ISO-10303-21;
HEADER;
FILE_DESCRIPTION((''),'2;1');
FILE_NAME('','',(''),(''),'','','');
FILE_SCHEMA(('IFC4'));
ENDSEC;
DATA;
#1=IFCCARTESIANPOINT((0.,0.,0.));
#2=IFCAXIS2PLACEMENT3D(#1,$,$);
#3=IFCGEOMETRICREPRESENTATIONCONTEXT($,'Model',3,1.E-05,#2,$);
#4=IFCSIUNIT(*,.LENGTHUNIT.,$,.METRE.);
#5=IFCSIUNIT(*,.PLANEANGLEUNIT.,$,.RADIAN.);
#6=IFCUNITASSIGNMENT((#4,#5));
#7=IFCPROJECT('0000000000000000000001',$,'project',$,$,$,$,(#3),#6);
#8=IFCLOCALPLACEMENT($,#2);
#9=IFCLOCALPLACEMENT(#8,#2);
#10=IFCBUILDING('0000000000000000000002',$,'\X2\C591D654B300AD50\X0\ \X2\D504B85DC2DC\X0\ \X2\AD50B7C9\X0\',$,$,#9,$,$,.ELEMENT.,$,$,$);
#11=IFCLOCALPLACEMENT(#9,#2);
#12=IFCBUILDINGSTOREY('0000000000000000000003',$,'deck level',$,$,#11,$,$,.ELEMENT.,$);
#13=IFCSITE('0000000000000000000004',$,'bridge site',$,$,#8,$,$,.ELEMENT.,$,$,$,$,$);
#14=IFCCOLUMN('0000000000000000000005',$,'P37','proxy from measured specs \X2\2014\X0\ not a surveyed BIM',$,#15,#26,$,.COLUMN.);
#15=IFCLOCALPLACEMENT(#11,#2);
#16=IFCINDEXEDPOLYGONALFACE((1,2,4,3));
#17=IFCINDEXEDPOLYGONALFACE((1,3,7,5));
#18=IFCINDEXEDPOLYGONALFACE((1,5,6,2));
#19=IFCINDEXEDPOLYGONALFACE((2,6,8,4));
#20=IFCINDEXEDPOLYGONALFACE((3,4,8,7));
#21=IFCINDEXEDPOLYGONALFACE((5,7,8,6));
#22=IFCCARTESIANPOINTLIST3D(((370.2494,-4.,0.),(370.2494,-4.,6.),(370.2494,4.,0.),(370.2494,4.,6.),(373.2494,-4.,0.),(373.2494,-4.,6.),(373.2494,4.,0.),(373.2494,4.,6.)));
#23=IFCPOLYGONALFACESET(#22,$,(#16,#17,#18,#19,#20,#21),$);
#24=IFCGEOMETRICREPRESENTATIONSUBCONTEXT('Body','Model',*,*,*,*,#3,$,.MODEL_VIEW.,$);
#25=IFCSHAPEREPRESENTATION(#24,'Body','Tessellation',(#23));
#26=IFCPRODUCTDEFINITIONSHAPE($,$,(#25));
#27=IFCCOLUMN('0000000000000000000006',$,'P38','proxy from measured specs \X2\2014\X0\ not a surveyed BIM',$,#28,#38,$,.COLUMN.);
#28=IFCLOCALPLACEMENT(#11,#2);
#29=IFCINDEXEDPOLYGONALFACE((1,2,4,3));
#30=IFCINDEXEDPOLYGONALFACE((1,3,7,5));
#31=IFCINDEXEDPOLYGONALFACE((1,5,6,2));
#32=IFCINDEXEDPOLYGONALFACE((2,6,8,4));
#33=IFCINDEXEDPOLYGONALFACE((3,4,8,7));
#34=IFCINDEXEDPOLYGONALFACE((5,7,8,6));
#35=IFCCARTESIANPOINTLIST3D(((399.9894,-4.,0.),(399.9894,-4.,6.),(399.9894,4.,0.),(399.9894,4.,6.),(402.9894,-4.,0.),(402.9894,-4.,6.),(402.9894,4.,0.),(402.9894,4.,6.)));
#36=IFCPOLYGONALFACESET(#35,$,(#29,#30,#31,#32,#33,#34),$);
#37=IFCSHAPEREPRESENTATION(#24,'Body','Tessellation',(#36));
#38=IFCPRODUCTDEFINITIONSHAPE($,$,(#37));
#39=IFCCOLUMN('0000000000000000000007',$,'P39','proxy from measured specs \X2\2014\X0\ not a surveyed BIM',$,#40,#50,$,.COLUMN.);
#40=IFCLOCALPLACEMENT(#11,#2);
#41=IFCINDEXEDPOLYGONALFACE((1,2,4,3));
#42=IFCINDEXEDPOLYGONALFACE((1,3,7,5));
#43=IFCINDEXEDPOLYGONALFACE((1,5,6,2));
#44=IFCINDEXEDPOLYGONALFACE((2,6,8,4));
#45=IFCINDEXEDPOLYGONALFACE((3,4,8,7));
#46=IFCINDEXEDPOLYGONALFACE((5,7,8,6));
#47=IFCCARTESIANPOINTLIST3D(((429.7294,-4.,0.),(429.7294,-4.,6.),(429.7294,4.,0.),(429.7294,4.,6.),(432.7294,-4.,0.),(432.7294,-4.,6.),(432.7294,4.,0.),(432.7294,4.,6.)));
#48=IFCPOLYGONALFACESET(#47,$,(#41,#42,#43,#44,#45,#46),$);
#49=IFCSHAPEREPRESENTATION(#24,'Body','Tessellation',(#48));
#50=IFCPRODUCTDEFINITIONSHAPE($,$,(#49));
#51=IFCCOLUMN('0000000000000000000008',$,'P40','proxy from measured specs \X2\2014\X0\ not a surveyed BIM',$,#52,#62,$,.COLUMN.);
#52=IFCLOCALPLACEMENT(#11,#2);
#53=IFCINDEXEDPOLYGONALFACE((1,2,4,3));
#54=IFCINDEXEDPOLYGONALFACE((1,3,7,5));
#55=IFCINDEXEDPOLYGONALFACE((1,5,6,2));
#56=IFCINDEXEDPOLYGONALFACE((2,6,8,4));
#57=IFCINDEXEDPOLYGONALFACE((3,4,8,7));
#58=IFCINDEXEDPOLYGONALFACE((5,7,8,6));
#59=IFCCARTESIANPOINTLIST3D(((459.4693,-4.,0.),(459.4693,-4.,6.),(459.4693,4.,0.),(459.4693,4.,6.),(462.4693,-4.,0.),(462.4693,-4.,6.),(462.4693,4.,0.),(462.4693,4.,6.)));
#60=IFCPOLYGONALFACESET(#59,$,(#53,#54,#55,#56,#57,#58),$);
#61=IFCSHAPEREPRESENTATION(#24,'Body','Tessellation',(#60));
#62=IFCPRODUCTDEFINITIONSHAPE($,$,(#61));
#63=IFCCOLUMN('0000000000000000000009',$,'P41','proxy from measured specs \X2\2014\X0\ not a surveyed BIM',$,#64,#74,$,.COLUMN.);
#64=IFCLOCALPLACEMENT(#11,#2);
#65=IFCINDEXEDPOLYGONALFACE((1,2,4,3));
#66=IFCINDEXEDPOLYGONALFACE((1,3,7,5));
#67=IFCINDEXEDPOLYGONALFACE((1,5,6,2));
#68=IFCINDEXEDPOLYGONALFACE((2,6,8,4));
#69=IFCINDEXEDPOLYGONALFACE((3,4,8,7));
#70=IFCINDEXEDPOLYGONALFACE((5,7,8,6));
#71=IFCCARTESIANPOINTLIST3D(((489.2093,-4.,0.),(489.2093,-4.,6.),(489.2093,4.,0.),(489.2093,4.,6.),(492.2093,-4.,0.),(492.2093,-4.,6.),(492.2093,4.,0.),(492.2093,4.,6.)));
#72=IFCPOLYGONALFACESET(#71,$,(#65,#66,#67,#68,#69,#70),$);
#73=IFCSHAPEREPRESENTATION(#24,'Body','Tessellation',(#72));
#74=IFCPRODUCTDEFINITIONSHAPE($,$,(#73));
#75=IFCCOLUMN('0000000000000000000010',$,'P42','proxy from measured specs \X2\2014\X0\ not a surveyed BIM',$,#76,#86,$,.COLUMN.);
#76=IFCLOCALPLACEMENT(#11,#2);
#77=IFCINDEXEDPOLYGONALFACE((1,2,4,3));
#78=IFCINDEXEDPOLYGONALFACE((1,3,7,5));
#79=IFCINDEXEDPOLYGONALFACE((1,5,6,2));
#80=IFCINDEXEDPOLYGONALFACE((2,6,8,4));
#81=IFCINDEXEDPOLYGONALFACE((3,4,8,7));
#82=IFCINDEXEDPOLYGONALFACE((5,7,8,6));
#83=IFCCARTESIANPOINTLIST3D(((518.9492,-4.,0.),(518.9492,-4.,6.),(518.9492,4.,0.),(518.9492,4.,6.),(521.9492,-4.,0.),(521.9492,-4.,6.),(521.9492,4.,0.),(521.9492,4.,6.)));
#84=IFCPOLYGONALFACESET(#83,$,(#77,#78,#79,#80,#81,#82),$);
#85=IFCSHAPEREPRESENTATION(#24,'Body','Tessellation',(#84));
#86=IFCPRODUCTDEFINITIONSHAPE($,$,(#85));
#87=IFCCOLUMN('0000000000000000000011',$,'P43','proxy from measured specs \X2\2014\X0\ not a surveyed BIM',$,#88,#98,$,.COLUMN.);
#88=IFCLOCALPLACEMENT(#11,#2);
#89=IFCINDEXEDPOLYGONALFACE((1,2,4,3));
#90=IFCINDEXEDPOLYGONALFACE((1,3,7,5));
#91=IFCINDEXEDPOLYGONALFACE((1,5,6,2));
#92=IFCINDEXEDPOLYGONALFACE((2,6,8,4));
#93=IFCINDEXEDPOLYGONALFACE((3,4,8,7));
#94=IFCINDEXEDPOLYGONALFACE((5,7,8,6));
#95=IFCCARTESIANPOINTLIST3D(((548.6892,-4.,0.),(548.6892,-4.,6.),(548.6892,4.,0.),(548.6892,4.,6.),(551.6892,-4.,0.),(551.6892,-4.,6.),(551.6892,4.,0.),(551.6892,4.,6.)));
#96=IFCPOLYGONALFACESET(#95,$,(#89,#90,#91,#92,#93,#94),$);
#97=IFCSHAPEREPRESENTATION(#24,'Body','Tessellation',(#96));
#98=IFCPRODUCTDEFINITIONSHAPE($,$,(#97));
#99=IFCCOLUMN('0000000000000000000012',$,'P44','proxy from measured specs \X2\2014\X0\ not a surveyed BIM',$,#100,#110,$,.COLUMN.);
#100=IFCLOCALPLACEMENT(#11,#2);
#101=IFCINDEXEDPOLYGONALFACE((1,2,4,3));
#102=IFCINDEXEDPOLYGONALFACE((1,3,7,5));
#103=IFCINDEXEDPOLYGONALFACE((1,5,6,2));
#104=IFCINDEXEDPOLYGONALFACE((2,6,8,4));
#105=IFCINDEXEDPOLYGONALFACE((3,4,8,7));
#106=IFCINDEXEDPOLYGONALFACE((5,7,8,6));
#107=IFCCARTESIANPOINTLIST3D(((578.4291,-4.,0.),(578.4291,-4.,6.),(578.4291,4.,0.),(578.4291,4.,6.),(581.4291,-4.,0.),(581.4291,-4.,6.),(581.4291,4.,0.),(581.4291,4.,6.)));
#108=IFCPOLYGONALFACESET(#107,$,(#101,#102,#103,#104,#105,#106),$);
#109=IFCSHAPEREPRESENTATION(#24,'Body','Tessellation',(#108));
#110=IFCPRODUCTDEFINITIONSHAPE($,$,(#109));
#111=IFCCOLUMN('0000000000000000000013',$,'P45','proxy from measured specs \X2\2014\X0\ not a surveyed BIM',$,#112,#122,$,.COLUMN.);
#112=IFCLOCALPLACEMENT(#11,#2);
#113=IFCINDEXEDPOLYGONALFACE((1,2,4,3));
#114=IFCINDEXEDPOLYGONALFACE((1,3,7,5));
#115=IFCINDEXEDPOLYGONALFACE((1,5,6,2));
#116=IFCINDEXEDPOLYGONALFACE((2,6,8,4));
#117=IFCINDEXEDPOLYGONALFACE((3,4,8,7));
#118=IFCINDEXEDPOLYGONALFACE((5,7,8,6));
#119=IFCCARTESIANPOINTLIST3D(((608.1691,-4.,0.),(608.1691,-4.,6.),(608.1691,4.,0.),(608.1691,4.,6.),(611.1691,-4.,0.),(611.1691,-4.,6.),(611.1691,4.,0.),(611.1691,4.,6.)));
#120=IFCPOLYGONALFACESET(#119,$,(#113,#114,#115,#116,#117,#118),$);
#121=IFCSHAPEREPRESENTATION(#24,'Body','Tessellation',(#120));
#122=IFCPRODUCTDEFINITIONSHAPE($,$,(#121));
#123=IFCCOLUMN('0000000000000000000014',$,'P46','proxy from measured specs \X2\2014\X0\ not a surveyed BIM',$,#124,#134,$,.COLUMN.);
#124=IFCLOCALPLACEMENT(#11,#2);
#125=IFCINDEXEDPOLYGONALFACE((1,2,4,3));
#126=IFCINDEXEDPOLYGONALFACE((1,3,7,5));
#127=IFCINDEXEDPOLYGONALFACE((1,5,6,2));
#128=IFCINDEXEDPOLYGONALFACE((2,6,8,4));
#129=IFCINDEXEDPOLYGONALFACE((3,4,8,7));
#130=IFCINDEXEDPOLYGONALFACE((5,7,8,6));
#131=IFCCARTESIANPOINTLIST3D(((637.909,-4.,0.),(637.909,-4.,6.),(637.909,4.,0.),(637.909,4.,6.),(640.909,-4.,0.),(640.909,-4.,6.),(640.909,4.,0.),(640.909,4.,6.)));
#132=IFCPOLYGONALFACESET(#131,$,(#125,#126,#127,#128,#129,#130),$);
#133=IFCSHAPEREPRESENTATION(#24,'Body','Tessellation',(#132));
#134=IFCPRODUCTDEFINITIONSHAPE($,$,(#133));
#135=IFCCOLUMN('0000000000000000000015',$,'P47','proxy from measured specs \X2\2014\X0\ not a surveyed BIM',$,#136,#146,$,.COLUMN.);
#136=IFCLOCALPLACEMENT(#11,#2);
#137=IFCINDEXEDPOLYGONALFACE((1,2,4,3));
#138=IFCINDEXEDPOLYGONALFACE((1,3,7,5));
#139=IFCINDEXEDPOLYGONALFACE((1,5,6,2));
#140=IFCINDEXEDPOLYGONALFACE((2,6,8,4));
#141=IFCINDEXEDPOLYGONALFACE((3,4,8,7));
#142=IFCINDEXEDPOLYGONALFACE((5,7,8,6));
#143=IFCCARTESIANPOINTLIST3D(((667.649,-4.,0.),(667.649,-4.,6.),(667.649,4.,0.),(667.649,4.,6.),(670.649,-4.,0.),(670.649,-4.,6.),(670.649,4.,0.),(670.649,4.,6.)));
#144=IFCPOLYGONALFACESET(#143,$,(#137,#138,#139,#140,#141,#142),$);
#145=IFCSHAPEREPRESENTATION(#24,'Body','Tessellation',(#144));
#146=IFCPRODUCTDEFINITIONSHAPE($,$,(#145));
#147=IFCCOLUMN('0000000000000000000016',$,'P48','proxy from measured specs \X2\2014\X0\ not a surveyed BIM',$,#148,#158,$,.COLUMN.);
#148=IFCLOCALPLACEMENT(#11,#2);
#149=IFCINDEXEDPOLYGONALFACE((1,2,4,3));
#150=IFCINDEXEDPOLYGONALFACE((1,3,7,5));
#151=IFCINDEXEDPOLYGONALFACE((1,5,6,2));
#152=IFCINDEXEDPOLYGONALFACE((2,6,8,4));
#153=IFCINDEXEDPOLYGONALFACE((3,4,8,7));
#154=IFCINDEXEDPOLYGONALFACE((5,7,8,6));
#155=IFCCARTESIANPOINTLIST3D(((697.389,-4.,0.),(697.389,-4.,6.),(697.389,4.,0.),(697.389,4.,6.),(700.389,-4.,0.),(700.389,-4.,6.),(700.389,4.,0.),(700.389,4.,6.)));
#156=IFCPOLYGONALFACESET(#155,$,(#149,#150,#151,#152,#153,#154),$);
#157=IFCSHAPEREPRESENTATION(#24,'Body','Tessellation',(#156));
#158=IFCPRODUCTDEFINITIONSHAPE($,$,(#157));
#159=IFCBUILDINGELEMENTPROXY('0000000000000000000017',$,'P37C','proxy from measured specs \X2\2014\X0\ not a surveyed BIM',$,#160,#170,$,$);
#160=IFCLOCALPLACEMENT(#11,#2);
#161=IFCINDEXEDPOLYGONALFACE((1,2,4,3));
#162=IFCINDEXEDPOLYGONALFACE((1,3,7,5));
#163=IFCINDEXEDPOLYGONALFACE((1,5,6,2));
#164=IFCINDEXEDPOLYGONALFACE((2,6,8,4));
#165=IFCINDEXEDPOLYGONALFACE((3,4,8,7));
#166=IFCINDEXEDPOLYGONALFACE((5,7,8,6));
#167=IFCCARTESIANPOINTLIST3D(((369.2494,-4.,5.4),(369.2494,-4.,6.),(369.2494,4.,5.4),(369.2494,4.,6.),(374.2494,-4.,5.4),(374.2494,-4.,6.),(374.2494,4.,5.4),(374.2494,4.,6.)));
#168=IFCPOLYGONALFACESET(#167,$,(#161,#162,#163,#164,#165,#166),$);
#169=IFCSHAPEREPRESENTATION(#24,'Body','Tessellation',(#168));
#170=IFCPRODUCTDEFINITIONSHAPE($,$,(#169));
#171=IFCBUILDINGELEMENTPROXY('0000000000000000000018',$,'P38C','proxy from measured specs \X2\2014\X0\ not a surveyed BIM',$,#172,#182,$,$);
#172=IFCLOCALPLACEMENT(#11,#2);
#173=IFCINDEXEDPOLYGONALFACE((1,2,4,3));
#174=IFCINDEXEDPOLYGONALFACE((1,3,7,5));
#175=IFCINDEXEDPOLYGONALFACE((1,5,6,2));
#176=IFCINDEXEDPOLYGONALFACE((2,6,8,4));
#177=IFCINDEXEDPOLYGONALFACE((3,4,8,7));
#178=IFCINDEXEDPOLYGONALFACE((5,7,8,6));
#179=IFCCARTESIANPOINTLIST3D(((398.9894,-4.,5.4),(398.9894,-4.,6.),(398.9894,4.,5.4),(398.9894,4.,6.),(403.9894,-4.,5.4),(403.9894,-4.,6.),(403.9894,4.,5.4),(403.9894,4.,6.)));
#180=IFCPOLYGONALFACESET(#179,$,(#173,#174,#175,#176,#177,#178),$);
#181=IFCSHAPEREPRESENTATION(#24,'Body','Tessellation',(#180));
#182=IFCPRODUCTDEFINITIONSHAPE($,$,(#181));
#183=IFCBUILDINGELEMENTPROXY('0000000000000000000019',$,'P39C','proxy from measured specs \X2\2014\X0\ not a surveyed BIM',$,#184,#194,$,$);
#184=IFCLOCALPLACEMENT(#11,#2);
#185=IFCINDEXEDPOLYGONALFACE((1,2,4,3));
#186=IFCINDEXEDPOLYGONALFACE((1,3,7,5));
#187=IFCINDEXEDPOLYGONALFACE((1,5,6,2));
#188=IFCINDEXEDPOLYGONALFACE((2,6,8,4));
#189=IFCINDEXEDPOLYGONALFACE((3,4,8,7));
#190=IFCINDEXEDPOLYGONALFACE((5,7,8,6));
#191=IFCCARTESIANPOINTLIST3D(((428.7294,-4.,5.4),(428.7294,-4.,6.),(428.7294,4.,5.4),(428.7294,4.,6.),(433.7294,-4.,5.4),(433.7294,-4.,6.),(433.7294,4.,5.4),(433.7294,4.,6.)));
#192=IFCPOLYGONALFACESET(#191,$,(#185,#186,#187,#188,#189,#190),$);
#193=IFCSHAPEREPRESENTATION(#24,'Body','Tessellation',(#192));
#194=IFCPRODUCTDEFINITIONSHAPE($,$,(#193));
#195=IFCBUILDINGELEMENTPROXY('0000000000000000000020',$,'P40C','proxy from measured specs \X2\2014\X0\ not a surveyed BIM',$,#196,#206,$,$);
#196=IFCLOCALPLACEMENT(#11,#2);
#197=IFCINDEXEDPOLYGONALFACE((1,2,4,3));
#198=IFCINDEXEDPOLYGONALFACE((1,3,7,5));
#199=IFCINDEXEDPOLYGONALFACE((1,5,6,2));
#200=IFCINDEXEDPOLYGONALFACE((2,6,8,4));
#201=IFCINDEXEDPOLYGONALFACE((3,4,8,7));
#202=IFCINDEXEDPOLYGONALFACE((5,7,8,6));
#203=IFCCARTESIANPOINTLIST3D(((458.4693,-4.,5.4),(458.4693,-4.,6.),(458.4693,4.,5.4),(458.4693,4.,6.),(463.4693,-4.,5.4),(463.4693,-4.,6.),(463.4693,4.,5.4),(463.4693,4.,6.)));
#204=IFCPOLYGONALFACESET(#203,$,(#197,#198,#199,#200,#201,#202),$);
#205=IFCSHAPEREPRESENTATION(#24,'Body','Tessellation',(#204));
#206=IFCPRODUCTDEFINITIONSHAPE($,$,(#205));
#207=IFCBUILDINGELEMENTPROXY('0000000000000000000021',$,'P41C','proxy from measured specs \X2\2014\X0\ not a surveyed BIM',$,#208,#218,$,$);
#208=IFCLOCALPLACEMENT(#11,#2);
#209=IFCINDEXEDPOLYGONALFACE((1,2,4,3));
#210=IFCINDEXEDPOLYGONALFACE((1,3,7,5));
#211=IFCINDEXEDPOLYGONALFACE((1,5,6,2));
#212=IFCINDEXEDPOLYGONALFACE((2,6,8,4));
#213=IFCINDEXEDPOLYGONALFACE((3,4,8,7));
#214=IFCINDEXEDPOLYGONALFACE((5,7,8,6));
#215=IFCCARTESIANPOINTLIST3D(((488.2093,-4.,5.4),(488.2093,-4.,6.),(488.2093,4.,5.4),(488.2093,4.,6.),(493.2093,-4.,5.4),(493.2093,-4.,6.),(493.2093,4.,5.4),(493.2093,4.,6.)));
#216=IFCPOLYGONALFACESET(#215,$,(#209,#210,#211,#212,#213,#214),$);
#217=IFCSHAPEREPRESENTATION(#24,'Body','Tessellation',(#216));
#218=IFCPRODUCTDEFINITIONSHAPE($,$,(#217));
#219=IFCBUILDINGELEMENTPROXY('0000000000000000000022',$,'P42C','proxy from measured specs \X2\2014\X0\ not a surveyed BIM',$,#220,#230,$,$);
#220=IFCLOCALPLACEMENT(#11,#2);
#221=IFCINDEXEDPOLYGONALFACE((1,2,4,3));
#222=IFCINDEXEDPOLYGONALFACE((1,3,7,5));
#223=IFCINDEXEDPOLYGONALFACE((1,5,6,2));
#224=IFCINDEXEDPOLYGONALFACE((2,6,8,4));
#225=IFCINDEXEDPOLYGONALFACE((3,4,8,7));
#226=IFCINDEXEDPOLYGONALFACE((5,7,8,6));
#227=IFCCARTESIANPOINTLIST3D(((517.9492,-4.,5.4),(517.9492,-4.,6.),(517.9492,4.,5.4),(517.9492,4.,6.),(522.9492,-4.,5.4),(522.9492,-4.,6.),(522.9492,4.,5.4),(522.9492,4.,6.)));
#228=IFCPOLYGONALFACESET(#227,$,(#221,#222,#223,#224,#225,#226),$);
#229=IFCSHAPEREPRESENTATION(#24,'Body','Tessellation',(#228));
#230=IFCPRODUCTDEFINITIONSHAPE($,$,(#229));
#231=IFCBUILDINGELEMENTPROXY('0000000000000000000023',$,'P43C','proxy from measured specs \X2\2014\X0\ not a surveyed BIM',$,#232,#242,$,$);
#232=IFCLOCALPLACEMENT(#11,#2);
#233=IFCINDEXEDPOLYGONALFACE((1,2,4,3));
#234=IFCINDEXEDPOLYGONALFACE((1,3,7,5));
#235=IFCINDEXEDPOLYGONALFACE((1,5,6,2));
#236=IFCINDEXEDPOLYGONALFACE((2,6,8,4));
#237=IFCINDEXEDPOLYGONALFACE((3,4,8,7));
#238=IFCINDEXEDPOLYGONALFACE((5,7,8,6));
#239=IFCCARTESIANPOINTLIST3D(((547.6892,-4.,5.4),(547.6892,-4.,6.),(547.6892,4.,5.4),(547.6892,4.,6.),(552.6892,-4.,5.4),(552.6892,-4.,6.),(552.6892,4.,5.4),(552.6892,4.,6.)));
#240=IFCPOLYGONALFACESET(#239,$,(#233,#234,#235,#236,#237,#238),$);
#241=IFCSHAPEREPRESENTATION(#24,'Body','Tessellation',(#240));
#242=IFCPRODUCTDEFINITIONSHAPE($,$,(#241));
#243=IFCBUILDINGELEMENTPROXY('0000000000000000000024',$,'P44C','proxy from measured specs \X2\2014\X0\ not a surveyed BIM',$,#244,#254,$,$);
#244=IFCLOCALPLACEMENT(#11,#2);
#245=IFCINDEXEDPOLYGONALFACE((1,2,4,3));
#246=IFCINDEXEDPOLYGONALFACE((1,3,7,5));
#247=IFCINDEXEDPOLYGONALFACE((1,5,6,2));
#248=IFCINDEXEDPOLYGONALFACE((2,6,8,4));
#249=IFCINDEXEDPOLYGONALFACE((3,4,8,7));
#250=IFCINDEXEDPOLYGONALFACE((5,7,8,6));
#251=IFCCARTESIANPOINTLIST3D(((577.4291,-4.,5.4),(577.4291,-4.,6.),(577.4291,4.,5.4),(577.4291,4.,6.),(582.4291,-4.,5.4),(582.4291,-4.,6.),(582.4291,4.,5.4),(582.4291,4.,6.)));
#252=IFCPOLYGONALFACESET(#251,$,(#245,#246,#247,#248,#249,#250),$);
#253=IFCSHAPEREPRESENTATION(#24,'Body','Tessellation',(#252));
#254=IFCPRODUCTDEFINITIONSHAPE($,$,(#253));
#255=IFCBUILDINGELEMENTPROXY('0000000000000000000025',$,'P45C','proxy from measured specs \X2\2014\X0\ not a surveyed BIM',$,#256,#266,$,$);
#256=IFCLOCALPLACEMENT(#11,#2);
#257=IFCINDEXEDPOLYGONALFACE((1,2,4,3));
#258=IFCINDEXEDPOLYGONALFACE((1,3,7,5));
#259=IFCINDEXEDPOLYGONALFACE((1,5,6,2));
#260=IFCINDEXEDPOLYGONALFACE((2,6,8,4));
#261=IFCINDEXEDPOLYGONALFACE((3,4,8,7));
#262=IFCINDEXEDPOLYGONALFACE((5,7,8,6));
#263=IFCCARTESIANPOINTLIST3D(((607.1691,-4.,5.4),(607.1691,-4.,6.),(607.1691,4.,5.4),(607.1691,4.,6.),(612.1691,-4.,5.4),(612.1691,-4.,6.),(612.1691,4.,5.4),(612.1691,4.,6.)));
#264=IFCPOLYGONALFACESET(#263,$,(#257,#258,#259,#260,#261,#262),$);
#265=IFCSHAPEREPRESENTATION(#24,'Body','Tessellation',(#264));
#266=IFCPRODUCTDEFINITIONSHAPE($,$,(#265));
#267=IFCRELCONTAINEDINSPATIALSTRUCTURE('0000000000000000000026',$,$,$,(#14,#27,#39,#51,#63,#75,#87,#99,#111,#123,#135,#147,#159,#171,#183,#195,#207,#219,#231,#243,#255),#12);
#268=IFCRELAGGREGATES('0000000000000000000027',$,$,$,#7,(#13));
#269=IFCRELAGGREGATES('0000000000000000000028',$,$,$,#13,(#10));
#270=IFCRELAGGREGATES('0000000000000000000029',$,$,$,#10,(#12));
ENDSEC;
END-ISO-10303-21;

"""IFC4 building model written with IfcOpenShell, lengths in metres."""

from ifc_helpers import new_model, si_unit, frame, origin, origin_2d, place, context, subcontext, project, spatial, rectangle, extrude, element, save


model = new_model("IFC4")

# Units and contexts
model_context = context("Model", 3, precision=1e-05, world=origin())
body_context = subcontext(model_context, "Body", "Model", "MODEL_VIEW")
ifc_project = project(units=[si_unit("LENGTHUNIT", "METRE"), si_unit("PLANEANGLEUNIT", "RADIAN")], contexts=[model_context])

# Site, building, storey
site_placement = place(None, origin())
site = spatial("IfcSite", under=ifc_project, at=site_placement, Name="bridge site", CompositionType="ELEMENT")
building_placement = place(site_placement, origin())
building = spatial("IfcBuilding", under=site, at=building_placement, Name="양화대교 프록시 교량", CompositionType="ELEMENT")
storey_placement = place(building_placement, origin())
storey = spatial("IfcBuildingStorey", under=building, at=storey_placement, Name="deck level", CompositionType="ELEMENT")

# Columns
for number, where, name in (
    (1, (371.7494, 0.0, 0.0), "P37"),
    (2, (401.4894, 0.0, 0.0), "P38"),
    (3, (431.2294, 0.0, 0.0), "P39"),
    (4, (460.9693, 0.0, 0.0), "P40"),
    (5, (490.7093, 0.0, 0.0), "P41"),
    (6, (520.4492, 0.0, 0.0), "P42"),
    (7, (550.1892, 0.0, 0.0), "P43"),
    (8, (579.9291, 0.0, 0.0), "P44"),
    (9, (609.6691, 0.0, 0.0), "P45"),
    (10, (639.409, 0.0, 0.0), "P46"),
    (11, (669.149, 0.0, 0.0), "P47"),
    (12, (698.889, 0.0, 0.0), "P48"),
):
    element("IfcColumn", number, at=place(storey_placement, frame(where)), inside=storey, Name=name, Description="proxy from measured specs — not a surveyed BIM", PredefinedType="COLUMN", context=body_context, shape_type="SweptSolid", body=[
        extrude(rectangle(XDim=3.0, YDim=8.0, at=origin_2d()), origin(), (0.0, 0.0, 1.0), 6.0),
    ])

# Building element proxies
for number, where, name in (
    (13, (371.7494, 0.0, 5.4), "P37C"),
    (14, (401.4894, 0.0, 5.4), "P38C"),
    (15, (431.2294, 0.0, 5.4), "P39C"),
    (16, (460.9693, 0.0, 5.4), "P40C"),
    (17, (490.7093, 0.0, 5.4), "P41C"),
    (18, (520.4492, 0.0, 5.4), "P42C"),
    (19, (550.1892, 0.0, 5.4), "P43C"),
    (20, (579.9291, 0.0, 5.4), "P44C"),
    (21, (609.6691, 0.0, 5.4), "P45C"),
):
    element("IfcBuildingElementProxy", number, at=place(storey_placement, frame(where)), inside=storey, Name=name, Description="proxy from measured specs — not a surveyed BIM", context=body_context, shape_type="SweptSolid", body=[
        extrude(rectangle(XDim=5.0, YDim=8.0, at=origin_2d()), origin(), (0.0, 0.0, 1.0), 0.6),
    ])

save(model, "model.ifc")
